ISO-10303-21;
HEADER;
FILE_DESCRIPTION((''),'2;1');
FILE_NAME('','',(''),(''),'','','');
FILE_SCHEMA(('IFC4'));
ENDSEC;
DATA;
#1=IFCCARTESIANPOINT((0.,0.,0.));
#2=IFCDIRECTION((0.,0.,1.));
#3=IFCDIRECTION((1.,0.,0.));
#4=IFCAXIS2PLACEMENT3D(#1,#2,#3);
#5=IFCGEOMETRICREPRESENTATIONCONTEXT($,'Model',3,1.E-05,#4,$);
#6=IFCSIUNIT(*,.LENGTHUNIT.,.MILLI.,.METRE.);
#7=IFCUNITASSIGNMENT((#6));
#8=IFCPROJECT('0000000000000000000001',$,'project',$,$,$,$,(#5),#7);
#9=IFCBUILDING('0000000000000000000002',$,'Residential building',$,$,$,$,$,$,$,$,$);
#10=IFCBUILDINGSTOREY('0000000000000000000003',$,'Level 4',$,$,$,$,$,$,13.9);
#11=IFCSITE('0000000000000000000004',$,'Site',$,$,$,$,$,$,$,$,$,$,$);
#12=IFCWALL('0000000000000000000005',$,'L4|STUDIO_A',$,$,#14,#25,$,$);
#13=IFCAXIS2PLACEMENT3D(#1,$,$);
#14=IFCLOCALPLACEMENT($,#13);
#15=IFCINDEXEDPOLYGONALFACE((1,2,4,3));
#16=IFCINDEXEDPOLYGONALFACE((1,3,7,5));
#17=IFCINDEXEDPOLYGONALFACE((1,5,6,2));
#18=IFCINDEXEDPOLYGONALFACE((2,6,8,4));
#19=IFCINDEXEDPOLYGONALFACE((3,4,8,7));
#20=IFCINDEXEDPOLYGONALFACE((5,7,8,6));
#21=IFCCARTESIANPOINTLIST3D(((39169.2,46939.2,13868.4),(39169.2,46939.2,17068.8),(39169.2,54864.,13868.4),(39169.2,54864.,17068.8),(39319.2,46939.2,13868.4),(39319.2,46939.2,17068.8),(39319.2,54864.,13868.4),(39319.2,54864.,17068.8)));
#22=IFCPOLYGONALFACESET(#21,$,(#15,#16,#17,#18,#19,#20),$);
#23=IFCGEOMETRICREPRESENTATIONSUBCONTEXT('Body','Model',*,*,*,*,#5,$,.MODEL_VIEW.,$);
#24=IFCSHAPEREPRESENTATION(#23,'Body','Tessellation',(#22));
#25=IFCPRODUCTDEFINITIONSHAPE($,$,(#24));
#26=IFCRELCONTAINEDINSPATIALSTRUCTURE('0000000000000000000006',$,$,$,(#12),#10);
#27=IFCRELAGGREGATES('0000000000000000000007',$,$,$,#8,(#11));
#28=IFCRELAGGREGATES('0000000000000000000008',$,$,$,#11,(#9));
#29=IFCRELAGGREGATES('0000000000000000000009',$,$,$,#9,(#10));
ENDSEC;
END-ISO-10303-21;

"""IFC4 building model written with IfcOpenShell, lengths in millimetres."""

from ifc_helpers import new_model, si_unit, frame, origin_with_axes, place, context, subcontext, project, spatial, indexed_curve, outline, extrude, element, save


model = new_model("IFC4")

# Units and contexts
model_context = context("Model", 3, precision=1e-05, world=origin_with_axes())
body_context = subcontext(model_context, "Body", "Model", "MODEL_VIEW")
ifc_project = project(units=[si_unit("LENGTHUNIT", "METRE", prefix="MILLI")], contexts=[model_context])

# Site, building, storey
site = spatial("IfcSite", under=ifc_project, Name="Site")
building = spatial("IfcBuilding", under=site, Name="Residential building")
storey = spatial("IfcBuildingStorey", under=building, Name="Level 4", Elevation=13.9)

# Wall
for number, where, z_axis, x_axis, name in (
    (1, (39319.2, 46939.2, 13868.4), (0.0, 0.0, 1.0), (0.0, 1.0, 0.0), "L4|STUDIO_A"),
):
    element("IfcWall", number, at=place(None, frame(where, z_axis=z_axis, x_axis=x_axis)), inside=storey, Name=name, context=body_context, shape_type="SweptSolid", body=[
        extrude(outline(indexed_curve([(0.0, 0.0), (0.0, 150.0), (7924.8, 150.0), (7924.8, 0.0), (0.0, 0.0)], self_intersect=False)), origin_with_axes(), (0.0, 0.0, 1.0), 3200.4),
    ])

save(model, "model.ifc")
